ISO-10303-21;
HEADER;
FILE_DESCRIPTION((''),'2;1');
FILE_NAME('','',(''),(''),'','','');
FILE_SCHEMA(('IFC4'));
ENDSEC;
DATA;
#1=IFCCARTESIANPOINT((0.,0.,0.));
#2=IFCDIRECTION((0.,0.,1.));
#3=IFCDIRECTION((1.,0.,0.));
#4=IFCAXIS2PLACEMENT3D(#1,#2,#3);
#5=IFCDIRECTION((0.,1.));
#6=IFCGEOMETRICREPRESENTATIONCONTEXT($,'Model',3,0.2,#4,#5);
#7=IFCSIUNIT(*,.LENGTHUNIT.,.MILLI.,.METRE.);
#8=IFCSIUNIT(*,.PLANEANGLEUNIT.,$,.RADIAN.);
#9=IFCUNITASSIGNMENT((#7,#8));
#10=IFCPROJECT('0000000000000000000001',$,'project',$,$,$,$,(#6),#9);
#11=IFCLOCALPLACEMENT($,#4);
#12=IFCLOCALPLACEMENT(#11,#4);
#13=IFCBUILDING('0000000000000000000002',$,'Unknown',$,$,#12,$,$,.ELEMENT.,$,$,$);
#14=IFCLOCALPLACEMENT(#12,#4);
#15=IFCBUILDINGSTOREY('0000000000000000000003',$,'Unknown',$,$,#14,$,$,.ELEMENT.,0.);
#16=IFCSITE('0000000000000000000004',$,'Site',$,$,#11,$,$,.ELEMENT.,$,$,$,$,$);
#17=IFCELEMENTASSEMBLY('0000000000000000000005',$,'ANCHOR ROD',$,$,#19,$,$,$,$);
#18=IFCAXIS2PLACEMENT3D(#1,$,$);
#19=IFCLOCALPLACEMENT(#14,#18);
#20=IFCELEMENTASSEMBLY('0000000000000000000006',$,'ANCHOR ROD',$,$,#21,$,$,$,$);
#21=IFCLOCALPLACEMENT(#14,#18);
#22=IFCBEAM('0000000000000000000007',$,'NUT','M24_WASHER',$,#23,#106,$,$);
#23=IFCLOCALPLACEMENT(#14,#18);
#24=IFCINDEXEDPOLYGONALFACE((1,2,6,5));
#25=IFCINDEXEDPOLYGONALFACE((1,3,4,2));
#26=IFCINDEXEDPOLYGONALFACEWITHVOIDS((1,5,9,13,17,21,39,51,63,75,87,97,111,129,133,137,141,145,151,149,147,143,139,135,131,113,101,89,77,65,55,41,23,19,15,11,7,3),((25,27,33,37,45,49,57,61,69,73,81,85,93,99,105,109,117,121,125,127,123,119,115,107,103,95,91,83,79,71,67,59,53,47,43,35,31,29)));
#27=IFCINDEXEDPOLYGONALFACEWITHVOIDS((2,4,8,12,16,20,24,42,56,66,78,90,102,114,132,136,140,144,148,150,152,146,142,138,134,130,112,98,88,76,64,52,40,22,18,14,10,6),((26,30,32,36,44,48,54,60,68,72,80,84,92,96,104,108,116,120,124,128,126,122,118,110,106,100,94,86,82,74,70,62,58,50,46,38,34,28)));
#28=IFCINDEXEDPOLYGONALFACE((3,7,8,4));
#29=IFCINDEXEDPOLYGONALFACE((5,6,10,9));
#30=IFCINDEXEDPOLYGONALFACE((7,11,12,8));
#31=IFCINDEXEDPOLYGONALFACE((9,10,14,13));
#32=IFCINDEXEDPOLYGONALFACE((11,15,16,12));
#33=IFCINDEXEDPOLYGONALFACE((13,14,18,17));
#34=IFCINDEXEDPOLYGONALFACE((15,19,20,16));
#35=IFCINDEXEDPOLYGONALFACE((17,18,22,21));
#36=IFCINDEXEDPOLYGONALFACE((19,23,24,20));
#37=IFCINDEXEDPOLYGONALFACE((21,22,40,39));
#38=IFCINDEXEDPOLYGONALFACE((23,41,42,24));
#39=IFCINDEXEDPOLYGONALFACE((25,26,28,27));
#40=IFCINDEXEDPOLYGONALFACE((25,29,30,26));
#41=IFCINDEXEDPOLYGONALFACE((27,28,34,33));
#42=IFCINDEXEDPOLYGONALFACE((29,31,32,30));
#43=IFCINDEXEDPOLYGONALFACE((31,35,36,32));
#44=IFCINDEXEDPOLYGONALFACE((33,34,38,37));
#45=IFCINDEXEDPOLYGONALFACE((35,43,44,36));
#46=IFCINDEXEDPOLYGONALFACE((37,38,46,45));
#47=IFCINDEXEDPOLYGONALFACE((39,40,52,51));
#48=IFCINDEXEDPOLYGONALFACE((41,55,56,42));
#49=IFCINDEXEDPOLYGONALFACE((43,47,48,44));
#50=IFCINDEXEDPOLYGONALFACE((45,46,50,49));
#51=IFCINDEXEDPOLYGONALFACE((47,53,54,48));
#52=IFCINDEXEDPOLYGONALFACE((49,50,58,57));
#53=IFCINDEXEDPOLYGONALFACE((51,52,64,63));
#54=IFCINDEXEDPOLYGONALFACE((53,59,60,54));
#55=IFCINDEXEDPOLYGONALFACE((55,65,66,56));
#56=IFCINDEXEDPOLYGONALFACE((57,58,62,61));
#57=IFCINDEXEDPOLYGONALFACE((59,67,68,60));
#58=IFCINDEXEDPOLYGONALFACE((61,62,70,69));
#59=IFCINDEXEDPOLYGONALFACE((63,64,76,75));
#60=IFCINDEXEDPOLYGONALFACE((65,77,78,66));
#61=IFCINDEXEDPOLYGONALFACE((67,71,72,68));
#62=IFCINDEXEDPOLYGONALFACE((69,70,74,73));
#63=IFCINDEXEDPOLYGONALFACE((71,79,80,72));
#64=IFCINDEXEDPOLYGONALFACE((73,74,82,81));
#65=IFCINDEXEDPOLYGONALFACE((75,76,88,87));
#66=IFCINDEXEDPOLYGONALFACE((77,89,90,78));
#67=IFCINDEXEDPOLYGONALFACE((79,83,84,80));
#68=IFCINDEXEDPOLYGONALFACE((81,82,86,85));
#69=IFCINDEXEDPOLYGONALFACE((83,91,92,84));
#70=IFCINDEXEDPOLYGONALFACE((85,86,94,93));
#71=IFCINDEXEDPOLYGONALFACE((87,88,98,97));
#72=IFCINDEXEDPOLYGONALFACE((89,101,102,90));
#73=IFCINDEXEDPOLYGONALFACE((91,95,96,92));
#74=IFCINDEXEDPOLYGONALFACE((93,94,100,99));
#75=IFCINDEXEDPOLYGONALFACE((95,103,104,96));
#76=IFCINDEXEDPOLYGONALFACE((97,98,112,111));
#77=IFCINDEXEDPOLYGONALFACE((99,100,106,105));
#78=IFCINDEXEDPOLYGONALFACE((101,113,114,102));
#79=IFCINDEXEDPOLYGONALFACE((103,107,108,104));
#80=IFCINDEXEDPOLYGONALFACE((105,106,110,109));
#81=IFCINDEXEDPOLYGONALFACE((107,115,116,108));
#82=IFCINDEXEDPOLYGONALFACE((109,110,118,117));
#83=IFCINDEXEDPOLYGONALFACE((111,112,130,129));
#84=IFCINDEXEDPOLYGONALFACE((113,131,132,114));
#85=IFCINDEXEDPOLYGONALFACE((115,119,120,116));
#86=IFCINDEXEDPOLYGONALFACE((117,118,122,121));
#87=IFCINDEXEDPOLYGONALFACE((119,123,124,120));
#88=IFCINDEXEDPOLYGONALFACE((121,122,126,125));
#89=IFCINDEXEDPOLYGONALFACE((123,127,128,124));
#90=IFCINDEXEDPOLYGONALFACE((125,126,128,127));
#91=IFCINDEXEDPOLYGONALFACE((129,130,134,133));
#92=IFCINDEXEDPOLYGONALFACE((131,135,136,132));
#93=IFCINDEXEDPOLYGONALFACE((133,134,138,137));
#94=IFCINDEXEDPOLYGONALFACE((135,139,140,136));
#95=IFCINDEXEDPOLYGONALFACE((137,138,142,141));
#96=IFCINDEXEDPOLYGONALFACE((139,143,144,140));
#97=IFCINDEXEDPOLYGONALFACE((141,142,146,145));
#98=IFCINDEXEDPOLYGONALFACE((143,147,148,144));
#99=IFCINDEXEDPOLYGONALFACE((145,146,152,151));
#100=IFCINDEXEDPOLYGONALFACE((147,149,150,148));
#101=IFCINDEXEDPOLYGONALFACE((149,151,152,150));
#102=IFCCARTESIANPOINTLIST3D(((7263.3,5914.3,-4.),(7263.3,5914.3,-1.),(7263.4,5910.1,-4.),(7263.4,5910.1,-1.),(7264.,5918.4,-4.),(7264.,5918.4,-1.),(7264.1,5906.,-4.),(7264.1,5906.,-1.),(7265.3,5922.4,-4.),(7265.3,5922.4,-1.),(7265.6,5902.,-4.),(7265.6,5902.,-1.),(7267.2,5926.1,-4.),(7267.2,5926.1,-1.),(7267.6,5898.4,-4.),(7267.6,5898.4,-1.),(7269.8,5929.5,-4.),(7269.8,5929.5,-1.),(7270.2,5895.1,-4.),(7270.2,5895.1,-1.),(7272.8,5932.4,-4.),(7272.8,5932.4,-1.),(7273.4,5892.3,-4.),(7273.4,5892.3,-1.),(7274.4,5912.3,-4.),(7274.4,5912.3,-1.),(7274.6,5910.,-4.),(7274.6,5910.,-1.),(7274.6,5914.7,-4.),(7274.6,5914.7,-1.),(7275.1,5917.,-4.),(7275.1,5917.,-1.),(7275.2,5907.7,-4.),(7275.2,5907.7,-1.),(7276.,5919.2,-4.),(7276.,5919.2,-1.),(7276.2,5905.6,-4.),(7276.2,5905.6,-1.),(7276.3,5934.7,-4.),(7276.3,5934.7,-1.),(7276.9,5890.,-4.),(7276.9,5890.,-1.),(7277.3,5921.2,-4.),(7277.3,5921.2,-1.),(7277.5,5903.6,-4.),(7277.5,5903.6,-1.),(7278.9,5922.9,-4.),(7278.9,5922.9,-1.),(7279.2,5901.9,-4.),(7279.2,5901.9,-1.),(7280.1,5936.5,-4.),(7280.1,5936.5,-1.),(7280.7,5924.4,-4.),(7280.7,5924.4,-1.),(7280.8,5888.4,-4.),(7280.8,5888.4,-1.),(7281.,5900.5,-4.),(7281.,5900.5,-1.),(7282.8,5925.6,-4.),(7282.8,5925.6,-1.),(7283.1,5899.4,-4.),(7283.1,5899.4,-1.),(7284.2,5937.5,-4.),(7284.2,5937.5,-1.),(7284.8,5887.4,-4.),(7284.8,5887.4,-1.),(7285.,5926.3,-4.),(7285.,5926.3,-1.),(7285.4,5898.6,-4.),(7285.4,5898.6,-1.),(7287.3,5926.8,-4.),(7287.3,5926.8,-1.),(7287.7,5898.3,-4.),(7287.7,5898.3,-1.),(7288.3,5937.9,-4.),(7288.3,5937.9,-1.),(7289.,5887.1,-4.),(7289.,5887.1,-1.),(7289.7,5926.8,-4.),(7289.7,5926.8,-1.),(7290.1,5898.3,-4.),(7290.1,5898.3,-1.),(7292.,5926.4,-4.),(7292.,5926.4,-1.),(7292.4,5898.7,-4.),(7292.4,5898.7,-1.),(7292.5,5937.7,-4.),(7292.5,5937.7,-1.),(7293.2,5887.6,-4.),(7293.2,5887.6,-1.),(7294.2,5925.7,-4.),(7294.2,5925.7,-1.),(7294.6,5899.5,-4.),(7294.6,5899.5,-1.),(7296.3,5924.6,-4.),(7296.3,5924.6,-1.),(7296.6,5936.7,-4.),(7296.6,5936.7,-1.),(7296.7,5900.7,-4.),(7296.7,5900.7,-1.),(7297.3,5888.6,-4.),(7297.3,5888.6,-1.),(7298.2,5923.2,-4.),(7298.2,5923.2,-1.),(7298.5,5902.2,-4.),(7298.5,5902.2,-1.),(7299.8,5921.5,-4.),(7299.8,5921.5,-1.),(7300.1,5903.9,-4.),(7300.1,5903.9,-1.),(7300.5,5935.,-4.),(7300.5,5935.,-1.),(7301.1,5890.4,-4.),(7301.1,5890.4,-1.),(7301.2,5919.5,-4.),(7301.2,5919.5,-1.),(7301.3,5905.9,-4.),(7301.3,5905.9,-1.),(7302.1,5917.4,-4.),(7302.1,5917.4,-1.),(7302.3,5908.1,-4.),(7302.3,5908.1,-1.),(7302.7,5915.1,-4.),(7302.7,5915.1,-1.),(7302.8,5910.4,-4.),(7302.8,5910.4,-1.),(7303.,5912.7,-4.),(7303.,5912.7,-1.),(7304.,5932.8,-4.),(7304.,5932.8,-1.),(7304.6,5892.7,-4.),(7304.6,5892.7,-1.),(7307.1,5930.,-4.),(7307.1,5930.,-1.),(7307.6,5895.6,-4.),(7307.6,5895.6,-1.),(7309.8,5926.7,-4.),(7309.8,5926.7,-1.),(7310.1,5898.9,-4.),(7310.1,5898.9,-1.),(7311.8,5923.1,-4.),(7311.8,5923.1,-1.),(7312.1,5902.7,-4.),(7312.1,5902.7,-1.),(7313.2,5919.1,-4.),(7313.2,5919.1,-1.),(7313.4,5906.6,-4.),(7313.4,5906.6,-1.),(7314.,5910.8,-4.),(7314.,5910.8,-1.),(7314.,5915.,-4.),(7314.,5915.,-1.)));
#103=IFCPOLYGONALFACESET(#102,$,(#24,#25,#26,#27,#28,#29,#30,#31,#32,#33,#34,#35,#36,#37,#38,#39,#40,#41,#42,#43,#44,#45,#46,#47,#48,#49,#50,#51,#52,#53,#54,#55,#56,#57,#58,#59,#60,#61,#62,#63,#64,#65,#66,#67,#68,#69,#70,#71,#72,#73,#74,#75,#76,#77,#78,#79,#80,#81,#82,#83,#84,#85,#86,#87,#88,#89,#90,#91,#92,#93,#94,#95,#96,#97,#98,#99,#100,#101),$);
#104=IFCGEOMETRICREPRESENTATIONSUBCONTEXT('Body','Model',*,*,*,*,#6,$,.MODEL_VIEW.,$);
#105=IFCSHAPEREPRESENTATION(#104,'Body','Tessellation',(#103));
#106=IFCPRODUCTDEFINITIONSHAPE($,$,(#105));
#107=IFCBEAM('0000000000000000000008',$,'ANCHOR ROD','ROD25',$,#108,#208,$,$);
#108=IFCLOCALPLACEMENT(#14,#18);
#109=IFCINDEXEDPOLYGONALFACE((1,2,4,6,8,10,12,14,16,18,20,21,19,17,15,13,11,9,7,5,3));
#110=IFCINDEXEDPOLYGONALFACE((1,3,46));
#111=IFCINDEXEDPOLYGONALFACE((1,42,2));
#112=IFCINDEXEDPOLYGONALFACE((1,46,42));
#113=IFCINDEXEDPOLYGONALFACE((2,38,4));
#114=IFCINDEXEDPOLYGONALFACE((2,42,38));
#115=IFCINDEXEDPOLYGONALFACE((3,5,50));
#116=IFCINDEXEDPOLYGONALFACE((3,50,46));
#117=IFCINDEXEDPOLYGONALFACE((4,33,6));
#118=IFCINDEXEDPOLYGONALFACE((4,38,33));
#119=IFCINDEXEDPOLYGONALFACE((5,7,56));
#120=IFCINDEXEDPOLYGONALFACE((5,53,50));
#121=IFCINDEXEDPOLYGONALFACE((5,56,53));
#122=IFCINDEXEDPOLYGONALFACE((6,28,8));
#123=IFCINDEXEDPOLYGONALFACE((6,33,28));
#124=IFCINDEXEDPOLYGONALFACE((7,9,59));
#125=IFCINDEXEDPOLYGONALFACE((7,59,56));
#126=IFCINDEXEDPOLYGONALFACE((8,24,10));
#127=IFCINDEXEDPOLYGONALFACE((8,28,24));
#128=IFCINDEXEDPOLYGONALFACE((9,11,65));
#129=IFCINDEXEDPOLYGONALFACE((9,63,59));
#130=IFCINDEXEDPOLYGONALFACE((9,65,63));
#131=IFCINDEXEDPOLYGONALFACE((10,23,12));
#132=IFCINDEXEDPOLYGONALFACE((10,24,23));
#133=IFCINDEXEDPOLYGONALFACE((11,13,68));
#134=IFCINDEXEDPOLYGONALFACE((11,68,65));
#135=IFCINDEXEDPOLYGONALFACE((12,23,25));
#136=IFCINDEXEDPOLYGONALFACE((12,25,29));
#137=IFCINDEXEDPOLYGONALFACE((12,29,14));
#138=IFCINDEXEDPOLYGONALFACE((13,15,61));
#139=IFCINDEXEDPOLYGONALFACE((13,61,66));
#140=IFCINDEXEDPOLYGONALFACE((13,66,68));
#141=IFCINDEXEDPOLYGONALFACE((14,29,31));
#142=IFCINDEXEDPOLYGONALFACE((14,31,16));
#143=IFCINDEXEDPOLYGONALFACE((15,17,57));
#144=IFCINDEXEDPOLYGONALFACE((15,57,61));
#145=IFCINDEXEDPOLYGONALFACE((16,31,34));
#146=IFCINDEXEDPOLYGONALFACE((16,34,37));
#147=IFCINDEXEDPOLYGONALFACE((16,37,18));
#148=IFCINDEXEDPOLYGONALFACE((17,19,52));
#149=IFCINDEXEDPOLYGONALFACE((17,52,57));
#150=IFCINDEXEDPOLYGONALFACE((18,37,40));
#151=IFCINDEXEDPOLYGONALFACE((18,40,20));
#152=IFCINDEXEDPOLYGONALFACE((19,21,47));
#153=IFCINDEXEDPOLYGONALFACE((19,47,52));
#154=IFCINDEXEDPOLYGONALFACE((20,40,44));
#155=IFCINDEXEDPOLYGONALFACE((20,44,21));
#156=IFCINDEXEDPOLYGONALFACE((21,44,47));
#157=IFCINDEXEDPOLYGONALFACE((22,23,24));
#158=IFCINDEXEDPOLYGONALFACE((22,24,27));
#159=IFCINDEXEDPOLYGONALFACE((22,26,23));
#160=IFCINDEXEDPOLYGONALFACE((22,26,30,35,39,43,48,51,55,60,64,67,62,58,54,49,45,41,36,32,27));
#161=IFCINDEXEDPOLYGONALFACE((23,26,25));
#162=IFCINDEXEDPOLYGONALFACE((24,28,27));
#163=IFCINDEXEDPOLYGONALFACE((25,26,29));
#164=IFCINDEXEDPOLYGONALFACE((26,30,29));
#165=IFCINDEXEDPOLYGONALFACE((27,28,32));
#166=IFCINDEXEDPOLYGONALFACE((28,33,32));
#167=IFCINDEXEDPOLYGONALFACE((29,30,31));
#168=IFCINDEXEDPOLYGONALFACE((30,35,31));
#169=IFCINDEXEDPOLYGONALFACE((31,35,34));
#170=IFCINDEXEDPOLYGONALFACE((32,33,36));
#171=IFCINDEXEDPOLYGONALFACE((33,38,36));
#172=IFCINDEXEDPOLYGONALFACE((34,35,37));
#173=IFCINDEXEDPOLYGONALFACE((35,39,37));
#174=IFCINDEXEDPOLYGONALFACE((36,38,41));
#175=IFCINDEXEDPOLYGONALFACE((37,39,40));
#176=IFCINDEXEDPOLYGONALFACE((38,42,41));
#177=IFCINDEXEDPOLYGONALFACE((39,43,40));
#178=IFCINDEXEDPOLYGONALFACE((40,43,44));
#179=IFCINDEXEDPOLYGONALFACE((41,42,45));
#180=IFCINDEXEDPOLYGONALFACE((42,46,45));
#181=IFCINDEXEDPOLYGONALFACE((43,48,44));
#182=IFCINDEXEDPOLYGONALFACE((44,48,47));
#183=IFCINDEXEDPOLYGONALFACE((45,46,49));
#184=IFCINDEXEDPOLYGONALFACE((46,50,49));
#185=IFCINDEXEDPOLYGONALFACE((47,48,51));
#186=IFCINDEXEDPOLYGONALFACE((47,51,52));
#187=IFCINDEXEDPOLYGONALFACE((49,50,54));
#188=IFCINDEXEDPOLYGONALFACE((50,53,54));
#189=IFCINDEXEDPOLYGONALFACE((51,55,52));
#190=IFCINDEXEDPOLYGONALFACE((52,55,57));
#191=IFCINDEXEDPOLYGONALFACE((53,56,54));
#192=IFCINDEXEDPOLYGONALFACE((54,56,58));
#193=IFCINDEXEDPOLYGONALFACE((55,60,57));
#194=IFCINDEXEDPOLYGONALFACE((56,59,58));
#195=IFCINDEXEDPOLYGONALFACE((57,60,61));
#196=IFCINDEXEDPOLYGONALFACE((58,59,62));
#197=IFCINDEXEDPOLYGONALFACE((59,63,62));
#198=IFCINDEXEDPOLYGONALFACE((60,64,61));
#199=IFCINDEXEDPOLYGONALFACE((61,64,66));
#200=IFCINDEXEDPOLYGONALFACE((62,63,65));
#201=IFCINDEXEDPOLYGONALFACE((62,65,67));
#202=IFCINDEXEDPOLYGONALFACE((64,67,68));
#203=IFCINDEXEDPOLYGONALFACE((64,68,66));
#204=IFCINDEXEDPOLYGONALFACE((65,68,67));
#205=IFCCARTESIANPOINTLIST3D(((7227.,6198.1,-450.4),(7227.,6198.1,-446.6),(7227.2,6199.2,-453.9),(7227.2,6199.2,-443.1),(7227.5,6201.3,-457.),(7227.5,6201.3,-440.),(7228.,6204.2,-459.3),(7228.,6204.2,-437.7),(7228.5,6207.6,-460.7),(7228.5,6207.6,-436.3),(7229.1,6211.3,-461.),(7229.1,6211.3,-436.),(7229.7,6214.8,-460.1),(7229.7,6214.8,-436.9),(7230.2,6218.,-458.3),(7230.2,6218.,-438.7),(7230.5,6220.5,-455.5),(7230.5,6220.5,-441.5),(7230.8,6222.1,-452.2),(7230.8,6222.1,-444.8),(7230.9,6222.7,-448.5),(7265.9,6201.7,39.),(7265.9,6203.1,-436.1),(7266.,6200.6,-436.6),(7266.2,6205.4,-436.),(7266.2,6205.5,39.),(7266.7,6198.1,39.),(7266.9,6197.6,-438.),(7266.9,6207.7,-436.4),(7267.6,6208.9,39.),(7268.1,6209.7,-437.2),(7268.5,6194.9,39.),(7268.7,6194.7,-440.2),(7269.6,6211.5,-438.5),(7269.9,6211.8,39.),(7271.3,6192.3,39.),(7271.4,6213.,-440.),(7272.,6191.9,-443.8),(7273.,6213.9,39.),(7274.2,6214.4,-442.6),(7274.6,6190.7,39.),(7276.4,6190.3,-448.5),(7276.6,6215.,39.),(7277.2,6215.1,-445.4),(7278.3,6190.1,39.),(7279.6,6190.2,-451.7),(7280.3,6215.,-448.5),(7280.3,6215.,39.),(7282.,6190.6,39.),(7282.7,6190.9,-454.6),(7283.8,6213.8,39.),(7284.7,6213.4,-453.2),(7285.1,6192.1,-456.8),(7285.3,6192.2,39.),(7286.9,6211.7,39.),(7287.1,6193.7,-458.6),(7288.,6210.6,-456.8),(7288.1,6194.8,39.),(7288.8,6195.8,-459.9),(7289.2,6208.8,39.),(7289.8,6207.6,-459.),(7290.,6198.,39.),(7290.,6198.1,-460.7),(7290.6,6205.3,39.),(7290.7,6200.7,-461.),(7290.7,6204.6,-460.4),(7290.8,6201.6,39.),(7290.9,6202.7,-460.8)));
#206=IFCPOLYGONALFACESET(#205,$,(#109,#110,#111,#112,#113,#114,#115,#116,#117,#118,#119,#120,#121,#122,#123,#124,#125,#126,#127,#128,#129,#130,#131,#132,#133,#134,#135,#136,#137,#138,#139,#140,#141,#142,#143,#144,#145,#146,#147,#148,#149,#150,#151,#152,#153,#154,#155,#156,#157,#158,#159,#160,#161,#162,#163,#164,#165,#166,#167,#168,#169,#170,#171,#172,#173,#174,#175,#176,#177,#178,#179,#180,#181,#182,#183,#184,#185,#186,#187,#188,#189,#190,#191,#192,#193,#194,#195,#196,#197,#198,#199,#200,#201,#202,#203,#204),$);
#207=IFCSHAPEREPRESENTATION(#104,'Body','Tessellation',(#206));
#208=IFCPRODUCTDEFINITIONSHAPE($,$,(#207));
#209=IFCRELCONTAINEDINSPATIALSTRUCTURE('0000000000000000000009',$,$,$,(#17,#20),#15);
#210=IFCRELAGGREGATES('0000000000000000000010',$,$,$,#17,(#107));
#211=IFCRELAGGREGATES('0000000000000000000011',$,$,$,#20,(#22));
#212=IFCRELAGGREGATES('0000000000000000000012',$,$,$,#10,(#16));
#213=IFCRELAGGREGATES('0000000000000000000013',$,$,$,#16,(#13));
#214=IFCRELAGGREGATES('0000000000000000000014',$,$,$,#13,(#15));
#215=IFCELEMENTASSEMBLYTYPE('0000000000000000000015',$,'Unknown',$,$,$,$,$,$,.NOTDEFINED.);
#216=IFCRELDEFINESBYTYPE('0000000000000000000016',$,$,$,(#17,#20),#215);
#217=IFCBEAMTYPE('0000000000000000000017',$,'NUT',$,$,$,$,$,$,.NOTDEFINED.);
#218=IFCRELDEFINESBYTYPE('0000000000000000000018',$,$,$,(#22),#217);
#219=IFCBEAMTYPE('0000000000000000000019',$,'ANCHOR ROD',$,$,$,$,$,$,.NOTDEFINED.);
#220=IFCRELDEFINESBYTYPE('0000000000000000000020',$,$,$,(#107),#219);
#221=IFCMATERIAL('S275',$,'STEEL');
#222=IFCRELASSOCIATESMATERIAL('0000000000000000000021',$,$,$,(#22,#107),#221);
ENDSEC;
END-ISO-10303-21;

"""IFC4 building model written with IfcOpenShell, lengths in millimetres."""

from ifc_helpers import new_model, entity, si_unit, direction, frame, origin_with_axes, place, context, subcontext, project, spatial, polyline, outline, extrude, material, material_profile, profile_set, profile_usage, type_object, element, aggregate, save


model = new_model("IFC4")

# Units and contexts
model_context = context("Model", 3, precision=0.2, world=origin_with_axes(), true_north=direction((0.0, 1.0)))
body_context = subcontext(model_context, "Body", "Model", "MODEL_VIEW")
ifc_project = project(units=[si_unit("LENGTHUNIT", "METRE", prefix="MILLI"), si_unit("PLANEANGLEUNIT", "RADIAN")], contexts=[model_context])

# Site, building, storey
site_placement = place(None, origin_with_axes())
site = spatial("IfcSite", under=ifc_project, at=site_placement, Name="Site", CompositionType="ELEMENT")
building_placement = place(site_placement, origin_with_axes())
building = spatial("IfcBuilding", under=site, at=building_placement, Name="Unknown", CompositionType="ELEMENT")
storey_placement = place(building_placement, origin_with_axes())
storey = spatial("IfcBuildingStorey", under=building, at=storey_placement, Name="Unknown", CompositionType="ELEMENT", Elevation=0.0)

# Element assemblies, beam
element_assembly_type = type_object("IfcElementAssemblyType", Name="Unknown", PredefinedType="NOTDEFINED")
assembly_1_placement = place(storey_placement, frame((7278.4, 6202.6, 39.0), z_axis=(0.154417, 0.988006, 0.0), x_axis=(0.0, 0.0, -1.0)))
assembly_1 = element("IfcElementAssembly", 1, at=assembly_1_placement, inside=storey, type_object=element_assembly_type, Name="ANCHOR ROD")
ifc_material_1 = material(Name="S275", Category="STEEL")
ifc_material_profile_1 = material_profile(ifc_material_1, outline(polyline([(25.4, 0.0), (25.1, 4.2), (24.0, 8.2), (22.3, 12.1), (20.0, 15.6), (17.2, 18.7), (13.9, 21.3), (10.2, 23.3), (6.2, 24.6), (2.1, 25.3), (-2.1, 25.3), (-6.2, 24.6), (-10.2, 23.3), (-13.9, 21.3), (-17.2, 18.7), (-20.0, 15.6), (-22.3, 12.1), (-24.0, 8.2), (-25.1, 4.2), (-25.4, 0.0), (-25.1, -4.2), (-24.0, -8.2), (-22.3, -12.1), (-20.0, -15.6), (-17.2, -18.7), (-13.9, -21.3), (-10.2, -23.3), (-6.2, -24.6), (-2.1, -25.3), (2.1, -25.3), (6.2, -24.6), (10.2, -23.3), (13.9, -21.3), (17.2, -18.7), (20.0, -15.6), (22.3, -12.1), (24.0, -8.2), (25.1, -4.2), (25.4, 0.0)]), holes=[polyline([(0.0, 14.3), (2.4, 14.1), (4.6, 13.5), (6.8, 12.6), (8.8, 11.3), (10.5, 9.7), (12.0, 7.8), (13.1, 5.7), (13.9, 3.5), (14.2, 1.2), (14.2, -1.2), (13.9, -3.5), (13.1, -5.7), (12.0, -7.8), (10.5, -9.7), (8.8, -11.3), (6.8, -12.6), (4.6, -13.5), (2.4, -14.1), (0.0, -14.3), (-2.4, -14.1), (-4.6, -13.5), (-6.8, -12.6), (-8.8, -11.3), (-10.5, -9.7), (-12.0, -7.8), (-13.1, -5.7), (-13.9, -3.5), (-14.2, -1.2), (-14.2, 1.2), (-13.9, 3.5), (-13.1, 5.7), (-12.0, 7.8), (-10.5, 9.7), (-8.8, 11.3), (-6.8, 12.6), (-4.6, 13.5), (-2.4, 14.1), (0.0, 14.3)])]), Name="M24_WASHER")
ifc_profile_set_1 = profile_set([ifc_material_profile_1])
ifc_profile_usage_1 = profile_usage(ifc_profile_set_1, cardinal=5)
beam_type_1 = type_object("IfcBeamType", Name="NUT", PredefinedType="NOTDEFINED")
assembly_2_placement = place(storey_placement, frame((7288.7, 5912.5, 39.0), z_axis=(0.154419, 0.988005, 0.0), x_axis=(0.0, 0.0, -1.0)))
assembly_2 = element("IfcElementAssembly", 2, at=assembly_2_placement, inside=storey, type_object=element_assembly_type, Name="ANCHOR ROD")
beam_1_placement = place(assembly_2_placement, frame((40.0, 0.0, 0.0), z_axis=(0.0, 0.003456, 0.999994), x_axis=(1.0, 0.0, 0.0)))
beam_1 = element("IfcBeam", 3, at=beam_1_placement, type_object=beam_type_1, material=ifc_profile_usage_1, Name="NUT", Description="M24_WASHER", context=body_context, shape_type="SolidModel", body=[
    extrude(outline(polyline([(25.4, 0.0), (25.1, 4.2), (24.0, 8.2), (22.3, 12.1), (20.0, 15.6), (17.2, 18.7), (13.9, 21.3), (10.2, 23.3), (6.2, 24.6), (2.1, 25.3), (-2.1, 25.3), (-6.2, 24.6), (-10.2, 23.3), (-13.9, 21.3), (-17.2, 18.7), (-20.0, 15.6), (-22.3, 12.1), (-24.0, 8.2), (-25.1, 4.2), (-25.4, 0.0), (-25.1, -4.2), (-24.0, -8.2), (-22.3, -12.1), (-20.0, -15.6), (-17.2, -18.7), (-13.9, -21.3), (-10.2, -23.3), (-6.2, -24.6), (-2.1, -25.3), (2.1, -25.3), (6.2, -24.6), (10.2, -23.3), (13.9, -21.3), (17.2, -18.7), (20.0, -15.6), (22.3, -12.1), (24.0, -8.2), (25.1, -4.2), (25.4, 0.0)]), holes=[polyline([(0.0, 14.3), (2.4, 14.1), (4.6, 13.5), (6.8, 12.6), (8.8, 11.3), (10.5, 9.7), (12.0, 7.8), (13.1, 5.7), (13.9, 3.5), (14.2, 1.2), (14.2, -1.2), (13.9, -3.5), (13.1, -5.7), (12.0, -7.8), (10.5, -9.7), (8.8, -11.3), (6.8, -12.6), (4.6, -13.5), (2.4, -14.1), (0.0, -14.3), (-2.4, -14.1), (-4.6, -13.5), (-6.8, -12.6), (-8.8, -11.3), (-10.5, -9.7), (-12.0, -7.8), (-13.1, -5.7), (-13.9, -3.5), (-14.2, -1.2), (-14.2, 1.2), (-13.9, 3.5), (-13.1, 5.7), (-12.0, 7.8), (-10.5, 9.7), (-8.8, 11.3), (-6.8, 12.6), (-4.6, 13.5), (-2.4, 14.1), (0.0, 14.3)])]), frame((0.0, 0.0, 0.0), z_axis=(-1.0, 0.0, 0.0), x_axis=(0.0, 0.0, 1.0)), (0.0, 0.0, -1.0), 3.0),
])

# Beam
beam_type_2 = type_object("IfcBeamType", Name="ANCHOR ROD", PredefinedType="NOTDEFINED")
beam_2_placement = place(assembly_1_placement, origin_with_axes())
beam_2 = element("IfcBeam", 4, at=beam_2_placement, type_object=beam_type_2, material=ifc_material_1, Name="ANCHOR ROD", Description="ROD25", context=body_context, shape_type="SolidModel", body=[
    entity("IfcSweptDiskSolid", entity("IfcIndexedPolyCurve", entity("IfcCartesianPointList3D", [[0.0, 0.0, 0.0], [487.5, 0.0, 0.0], [487.5, 50.0, 0.0]]), [entity("IfcLineIndex", [1, 2, 3])]), 12.5),
])
aggregate(assembly_1, [beam_2])
aggregate(assembly_2, [beam_1])

save(model, "model.ifc")
